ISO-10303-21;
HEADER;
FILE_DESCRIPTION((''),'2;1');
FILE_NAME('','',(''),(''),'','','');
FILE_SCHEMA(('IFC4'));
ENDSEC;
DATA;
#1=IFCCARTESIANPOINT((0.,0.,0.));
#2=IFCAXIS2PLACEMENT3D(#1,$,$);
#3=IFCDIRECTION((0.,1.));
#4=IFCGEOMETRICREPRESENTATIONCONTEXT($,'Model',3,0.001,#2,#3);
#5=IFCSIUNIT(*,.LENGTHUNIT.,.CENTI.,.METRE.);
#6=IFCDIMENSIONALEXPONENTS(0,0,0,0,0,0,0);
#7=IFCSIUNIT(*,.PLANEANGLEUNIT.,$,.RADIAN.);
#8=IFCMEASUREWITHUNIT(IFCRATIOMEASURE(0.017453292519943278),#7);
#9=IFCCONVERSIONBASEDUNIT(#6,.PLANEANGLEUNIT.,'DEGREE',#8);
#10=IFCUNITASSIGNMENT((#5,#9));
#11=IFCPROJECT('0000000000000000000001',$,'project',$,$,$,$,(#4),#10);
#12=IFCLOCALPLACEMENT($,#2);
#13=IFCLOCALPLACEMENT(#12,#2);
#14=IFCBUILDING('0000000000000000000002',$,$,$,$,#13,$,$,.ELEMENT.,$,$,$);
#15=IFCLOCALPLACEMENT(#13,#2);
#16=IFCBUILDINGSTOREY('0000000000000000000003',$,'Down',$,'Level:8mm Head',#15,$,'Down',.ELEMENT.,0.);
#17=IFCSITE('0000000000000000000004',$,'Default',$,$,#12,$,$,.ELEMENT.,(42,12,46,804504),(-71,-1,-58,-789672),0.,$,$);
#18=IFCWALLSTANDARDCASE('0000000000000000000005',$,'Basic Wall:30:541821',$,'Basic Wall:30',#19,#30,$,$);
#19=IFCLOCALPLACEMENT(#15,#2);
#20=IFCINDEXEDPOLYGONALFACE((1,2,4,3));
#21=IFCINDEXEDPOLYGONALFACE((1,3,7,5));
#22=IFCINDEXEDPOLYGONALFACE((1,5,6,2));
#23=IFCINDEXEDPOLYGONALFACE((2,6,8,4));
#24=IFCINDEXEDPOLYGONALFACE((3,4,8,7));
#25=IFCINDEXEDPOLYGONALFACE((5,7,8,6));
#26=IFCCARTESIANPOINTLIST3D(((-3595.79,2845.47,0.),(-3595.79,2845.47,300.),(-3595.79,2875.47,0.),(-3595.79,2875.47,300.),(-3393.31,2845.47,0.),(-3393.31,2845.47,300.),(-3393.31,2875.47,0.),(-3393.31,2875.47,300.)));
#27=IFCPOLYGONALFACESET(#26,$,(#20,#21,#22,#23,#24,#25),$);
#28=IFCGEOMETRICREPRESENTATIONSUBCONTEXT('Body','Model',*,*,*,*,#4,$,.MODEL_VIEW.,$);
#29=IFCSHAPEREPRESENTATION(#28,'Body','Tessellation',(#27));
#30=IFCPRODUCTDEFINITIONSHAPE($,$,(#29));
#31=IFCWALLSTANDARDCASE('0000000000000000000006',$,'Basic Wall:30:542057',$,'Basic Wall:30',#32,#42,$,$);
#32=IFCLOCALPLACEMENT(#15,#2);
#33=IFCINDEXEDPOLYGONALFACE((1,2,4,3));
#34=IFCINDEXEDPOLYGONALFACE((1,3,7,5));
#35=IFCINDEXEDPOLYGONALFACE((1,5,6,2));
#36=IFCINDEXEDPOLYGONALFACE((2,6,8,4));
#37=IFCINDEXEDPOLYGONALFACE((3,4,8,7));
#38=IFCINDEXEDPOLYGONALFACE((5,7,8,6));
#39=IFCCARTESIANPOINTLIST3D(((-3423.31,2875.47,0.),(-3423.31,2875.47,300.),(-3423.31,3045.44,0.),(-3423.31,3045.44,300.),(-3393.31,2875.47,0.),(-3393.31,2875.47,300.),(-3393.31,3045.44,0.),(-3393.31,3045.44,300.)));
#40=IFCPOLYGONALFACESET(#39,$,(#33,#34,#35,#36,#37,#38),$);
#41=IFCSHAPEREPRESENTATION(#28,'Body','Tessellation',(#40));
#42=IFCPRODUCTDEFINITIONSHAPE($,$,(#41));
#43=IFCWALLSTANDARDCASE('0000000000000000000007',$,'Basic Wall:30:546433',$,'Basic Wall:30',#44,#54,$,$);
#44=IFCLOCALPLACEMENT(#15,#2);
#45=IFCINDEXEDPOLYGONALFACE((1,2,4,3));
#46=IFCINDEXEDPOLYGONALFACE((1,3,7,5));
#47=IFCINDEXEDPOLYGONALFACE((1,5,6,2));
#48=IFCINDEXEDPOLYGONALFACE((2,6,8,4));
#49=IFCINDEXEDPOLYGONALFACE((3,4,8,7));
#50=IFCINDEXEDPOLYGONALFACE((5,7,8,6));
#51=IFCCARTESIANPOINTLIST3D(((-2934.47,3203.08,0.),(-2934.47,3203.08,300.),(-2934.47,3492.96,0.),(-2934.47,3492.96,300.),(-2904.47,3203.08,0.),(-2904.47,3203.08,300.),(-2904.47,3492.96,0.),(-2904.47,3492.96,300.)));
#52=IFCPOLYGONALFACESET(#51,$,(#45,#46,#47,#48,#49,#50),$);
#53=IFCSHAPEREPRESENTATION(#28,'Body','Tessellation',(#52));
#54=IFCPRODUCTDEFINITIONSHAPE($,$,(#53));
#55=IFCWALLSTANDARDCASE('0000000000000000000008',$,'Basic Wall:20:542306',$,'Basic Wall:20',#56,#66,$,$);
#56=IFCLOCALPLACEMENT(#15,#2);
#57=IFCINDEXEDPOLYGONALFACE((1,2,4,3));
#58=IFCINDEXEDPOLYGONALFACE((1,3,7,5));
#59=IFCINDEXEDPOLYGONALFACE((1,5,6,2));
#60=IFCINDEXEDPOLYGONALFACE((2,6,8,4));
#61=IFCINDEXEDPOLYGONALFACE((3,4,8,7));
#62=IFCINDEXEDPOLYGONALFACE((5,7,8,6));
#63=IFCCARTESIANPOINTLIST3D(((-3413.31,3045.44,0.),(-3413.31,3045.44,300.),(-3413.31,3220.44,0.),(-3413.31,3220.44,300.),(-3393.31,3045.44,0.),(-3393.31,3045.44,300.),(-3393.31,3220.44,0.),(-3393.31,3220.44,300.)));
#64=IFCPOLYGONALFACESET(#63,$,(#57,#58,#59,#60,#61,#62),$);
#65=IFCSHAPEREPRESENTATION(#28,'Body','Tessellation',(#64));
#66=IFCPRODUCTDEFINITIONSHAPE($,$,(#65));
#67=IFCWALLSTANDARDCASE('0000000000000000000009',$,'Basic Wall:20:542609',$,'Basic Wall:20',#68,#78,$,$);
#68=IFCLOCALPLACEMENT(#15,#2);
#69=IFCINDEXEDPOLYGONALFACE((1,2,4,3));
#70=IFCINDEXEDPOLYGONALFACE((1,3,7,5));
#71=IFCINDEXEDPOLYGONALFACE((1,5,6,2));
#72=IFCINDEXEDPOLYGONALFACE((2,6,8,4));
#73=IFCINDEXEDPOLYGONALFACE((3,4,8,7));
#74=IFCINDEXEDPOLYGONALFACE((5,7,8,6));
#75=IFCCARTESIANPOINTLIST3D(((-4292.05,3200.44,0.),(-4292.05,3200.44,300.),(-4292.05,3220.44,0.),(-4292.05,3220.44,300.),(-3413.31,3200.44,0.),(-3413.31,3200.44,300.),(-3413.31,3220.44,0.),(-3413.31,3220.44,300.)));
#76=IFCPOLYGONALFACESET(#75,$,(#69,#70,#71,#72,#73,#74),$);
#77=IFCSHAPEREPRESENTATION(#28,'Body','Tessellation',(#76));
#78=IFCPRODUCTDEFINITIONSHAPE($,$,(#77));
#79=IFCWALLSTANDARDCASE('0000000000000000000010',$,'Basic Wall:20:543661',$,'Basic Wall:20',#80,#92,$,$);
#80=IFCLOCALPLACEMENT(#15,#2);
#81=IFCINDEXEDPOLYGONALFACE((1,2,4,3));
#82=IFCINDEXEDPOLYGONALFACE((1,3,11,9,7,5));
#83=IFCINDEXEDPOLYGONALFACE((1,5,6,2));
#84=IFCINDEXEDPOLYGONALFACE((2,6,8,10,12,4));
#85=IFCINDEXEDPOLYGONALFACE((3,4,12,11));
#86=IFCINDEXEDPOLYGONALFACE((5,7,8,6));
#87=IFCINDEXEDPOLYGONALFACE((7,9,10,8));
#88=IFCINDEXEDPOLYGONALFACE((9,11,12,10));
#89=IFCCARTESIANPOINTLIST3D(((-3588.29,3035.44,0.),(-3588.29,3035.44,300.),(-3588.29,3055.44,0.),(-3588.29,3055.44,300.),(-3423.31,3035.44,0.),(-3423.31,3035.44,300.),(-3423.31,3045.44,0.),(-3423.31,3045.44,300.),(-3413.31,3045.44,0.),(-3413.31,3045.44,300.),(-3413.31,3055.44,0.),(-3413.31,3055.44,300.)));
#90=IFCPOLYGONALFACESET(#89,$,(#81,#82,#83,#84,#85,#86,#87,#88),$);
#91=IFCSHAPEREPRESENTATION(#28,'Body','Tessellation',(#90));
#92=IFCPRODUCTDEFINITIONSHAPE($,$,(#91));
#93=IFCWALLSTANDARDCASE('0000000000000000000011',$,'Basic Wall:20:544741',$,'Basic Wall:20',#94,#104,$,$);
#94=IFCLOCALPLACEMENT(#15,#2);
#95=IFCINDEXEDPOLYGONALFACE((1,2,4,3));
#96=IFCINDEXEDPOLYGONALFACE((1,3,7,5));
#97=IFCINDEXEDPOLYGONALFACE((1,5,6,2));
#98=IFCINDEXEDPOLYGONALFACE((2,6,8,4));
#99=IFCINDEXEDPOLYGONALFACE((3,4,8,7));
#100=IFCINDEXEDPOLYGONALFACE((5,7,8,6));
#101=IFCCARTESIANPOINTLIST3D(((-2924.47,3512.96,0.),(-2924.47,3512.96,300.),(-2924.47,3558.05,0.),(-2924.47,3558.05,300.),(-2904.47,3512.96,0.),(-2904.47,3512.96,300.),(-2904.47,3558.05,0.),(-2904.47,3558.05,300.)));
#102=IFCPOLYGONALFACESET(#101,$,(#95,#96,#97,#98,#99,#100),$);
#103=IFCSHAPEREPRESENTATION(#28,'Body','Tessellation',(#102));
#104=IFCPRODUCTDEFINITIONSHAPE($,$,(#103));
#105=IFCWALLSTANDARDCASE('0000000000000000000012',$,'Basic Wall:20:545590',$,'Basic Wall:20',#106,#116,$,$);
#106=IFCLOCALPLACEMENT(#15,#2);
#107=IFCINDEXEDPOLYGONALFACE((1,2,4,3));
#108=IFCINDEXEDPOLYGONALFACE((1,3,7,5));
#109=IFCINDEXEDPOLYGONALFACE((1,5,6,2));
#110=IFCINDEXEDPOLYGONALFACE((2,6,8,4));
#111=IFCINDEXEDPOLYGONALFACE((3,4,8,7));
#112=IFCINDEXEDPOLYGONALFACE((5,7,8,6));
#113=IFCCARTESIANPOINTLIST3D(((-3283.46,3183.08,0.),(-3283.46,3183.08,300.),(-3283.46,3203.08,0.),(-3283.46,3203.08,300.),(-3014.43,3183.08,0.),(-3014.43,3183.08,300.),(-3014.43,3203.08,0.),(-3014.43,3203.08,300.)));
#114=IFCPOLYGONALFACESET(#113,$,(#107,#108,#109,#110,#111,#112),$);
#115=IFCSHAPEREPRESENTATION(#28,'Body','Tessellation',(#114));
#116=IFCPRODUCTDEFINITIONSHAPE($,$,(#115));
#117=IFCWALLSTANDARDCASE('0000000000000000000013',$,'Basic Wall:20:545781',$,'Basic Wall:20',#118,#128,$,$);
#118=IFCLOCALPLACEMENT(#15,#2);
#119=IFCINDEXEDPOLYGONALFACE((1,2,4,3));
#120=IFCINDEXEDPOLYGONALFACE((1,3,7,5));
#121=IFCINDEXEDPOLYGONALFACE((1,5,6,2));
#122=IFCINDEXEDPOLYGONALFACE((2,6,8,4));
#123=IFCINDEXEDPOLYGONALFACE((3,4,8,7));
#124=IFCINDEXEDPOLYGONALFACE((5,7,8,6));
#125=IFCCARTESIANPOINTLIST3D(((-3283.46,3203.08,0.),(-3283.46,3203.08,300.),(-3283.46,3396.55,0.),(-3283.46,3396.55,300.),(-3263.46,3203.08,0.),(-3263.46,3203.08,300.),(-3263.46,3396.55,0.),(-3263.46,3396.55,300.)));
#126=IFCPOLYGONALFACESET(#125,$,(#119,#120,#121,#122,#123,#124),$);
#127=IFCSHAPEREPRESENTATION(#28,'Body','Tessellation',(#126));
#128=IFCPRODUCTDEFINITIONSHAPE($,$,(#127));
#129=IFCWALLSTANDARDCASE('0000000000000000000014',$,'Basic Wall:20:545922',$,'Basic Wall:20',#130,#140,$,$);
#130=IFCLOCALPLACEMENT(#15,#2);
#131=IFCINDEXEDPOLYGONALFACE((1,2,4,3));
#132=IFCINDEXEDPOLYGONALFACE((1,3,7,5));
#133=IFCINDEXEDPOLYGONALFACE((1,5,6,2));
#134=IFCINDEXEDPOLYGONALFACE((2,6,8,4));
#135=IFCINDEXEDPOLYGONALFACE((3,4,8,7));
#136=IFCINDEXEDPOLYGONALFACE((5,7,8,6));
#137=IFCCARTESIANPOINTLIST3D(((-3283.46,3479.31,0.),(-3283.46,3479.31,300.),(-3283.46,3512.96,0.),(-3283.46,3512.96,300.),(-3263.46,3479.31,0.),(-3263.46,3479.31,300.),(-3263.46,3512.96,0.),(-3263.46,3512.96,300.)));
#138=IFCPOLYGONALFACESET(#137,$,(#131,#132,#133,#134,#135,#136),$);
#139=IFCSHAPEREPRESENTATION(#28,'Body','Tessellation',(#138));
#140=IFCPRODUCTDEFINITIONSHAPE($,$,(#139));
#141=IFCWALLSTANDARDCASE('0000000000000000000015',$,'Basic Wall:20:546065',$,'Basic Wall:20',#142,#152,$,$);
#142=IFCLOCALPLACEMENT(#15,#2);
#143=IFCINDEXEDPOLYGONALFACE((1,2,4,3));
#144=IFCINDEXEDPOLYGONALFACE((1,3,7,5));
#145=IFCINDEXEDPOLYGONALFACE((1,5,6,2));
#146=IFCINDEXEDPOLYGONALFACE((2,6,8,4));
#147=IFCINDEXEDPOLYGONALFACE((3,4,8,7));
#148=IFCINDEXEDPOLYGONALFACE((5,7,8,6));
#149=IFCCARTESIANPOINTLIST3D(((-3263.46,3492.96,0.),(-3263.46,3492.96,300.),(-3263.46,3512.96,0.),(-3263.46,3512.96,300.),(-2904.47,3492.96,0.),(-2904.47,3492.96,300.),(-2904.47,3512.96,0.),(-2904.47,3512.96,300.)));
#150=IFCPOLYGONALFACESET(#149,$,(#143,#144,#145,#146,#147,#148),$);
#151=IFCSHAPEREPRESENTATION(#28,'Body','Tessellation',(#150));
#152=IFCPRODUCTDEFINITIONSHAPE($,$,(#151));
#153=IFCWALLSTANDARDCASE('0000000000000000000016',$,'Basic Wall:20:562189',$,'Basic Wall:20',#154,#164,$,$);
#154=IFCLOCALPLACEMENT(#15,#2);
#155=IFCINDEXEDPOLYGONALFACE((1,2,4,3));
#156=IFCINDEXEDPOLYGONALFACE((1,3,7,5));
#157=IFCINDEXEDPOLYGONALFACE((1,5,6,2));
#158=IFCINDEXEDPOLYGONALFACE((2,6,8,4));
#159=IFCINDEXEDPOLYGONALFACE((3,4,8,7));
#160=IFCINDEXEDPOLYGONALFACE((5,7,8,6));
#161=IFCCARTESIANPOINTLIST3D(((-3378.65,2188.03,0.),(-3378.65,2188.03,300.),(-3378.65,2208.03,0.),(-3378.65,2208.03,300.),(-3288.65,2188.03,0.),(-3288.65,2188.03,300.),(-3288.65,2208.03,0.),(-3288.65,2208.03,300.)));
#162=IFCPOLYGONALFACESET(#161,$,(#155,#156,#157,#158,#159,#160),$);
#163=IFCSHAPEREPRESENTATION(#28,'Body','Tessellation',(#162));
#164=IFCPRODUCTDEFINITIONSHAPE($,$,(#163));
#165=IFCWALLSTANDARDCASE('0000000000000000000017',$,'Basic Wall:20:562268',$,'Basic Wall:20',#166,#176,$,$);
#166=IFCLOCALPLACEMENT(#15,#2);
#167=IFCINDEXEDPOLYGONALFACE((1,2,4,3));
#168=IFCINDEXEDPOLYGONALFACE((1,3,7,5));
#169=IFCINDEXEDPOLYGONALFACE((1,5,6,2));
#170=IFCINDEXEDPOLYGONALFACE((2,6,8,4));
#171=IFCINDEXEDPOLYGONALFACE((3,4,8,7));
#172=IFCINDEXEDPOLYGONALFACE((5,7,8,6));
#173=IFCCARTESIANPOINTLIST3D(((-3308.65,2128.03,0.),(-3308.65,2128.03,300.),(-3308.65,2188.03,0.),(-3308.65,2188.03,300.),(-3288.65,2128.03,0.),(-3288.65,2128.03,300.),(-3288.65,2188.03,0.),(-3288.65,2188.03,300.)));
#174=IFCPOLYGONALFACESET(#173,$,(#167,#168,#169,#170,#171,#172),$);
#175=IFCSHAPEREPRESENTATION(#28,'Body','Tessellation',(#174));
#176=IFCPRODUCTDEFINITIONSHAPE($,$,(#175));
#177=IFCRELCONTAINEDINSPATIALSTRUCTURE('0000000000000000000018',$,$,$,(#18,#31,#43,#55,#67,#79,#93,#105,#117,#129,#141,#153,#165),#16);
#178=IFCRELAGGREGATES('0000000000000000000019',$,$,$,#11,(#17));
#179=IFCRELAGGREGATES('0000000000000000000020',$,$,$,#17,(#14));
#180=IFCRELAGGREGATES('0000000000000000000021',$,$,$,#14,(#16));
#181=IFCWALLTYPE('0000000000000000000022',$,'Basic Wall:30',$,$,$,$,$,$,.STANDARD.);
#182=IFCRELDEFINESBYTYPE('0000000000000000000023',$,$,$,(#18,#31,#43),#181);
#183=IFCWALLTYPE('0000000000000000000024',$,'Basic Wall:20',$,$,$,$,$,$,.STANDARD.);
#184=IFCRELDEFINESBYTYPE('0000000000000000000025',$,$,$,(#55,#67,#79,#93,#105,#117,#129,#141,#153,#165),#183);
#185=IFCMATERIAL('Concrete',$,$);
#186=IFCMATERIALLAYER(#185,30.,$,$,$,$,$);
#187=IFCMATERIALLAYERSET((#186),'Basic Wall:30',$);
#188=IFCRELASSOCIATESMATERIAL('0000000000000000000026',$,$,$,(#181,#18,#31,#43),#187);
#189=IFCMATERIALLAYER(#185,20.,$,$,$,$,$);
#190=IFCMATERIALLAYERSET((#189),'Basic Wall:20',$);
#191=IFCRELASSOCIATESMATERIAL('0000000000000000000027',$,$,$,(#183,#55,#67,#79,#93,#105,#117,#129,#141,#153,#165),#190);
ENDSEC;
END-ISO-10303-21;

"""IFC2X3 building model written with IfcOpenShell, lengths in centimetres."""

from ifc_helpers import new_model, entity, si_unit, converted_unit, direction, frame, frame_2d, origin, place, context, subcontext, project, spatial, polyline, rectangle, outline, extrude, material, layer, layer_set, layer_usage, type_object, element, save


model = new_model("IFC2X3")

# Units and contexts
model_context = context("Model", 3, precision=0.001, world=origin(), true_north=direction((0.0, 1.0)))
body_context = subcontext(model_context, "Body", "Model", "MODEL_VIEW")
ifc_project = project(units=[si_unit("LENGTHUNIT", "METRE", prefix="CENTI"), converted_unit("PLANEANGLEUNIT", "DEGREE", entity("IfcRatioMeasure", 0.017453292519943278), si_unit("PLANEANGLEUNIT", "RADIAN"), dimensions=[0, 0, 0, 0, 0, 0, 0])], contexts=[model_context])

# Site, building, storey
site_placement = place(None, origin())
site = spatial("IfcSite", under=ifc_project, at=site_placement, Name="Default", CompositionType="ELEMENT", RefLatitude=(42, 12, 46, 804504), RefLongitude=(-71, -1, -58, -789672), RefElevation=0.0)
building_placement = place(site_placement, origin())
building = spatial("IfcBuilding", under=site, at=building_placement, CompositionType="ELEMENT")
storey_placement = place(building_placement, origin())
storey = spatial("IfcBuildingStorey", under=building, at=storey_placement, Name="Down", ObjectType="Level:8mm Head", LongName="Down", CompositionType="ELEMENT", Elevation=0.0)

# Shared definitions
ifc_material = material(Name="Concrete")

# Walls
ifc_layer_1 = layer(ifc_material, 30.0)
ifc_layer_set_1 = layer_set([ifc_layer_1], Name="Basic Wall:30")
ifc_layer_usage_1 = layer_usage(ifc_layer_set_1, "AXIS2", "NEGATIVE", 15.0)
wall_type_1 = type_object("IfcWallType", Name="Basic Wall:30", PredefinedType="STANDARD", material=ifc_layer_set_1)
wall_1_placement = place(storey_placement, frame((-3393.31, 2860.47, 0.0), z_axis=(0.0, 0.0, 1.0), x_axis=(-1.0, 0.0, 0.0)))
element("IfcWallStandardCase", 1, at=wall_1_placement, inside=storey, type_object=wall_type_1, material=ifc_layer_usage_1, Name="Basic Wall:30:541821", ObjectType="Basic Wall:30", context=body_context, shape_type="SweptSolid", body=[
    extrude(rectangle(XDim=202.48, YDim=30.0, at=frame_2d((101.24, 0.0), x_axis=(-1.0, 0.0))), origin(), (0.0, 0.0, 1.0), 300.0),
])
ifc_layer_usage_2 = layer_usage(ifc_layer_set_1, "AXIS2", "POSITIVE", -15.0)
wall_2_placement = place(storey_placement, frame((-3408.31, 2875.47, 0.0), z_axis=(0.0, 0.0, 1.0), x_axis=(0.0, 1.0, 0.0)))
element("IfcWallStandardCase", 2, at=wall_2_placement, inside=storey, type_object=wall_type_1, material=ifc_layer_usage_2, Name="Basic Wall:30:542057", ObjectType="Basic Wall:30", context=body_context, shape_type="SweptSolid", body=[
    extrude(rectangle(XDim=169.97, YDim=30.0, at=frame_2d((84.99, 0.0), x_axis=(-1.0, 0.0))), origin(), (0.0, 0.0, 1.0), 300.0),
])
ifc_layer_usage_3 = layer_usage(ifc_layer_set_1, "AXIS2", "NEGATIVE", 15.0)
wall_3_placement = place(storey_placement, frame((-2919.47, 3492.96, 0.0), z_axis=(0.0, 0.0, 1.0), x_axis=(0.0, -1.0, 0.0)))
element("IfcWallStandardCase", 3, at=wall_3_placement, inside=storey, type_object=wall_type_1, material=ifc_layer_usage_3, Name="Basic Wall:30:546433", ObjectType="Basic Wall:30", context=body_context, shape_type="SweptSolid", body=[
    extrude(rectangle(XDim=289.88, YDim=30.0, at=frame_2d((144.94, 0.0), x_axis=(-1.0, 0.0))), origin(), (0.0, 0.0, 1.0), 300.0),
])
ifc_layer_2 = layer(ifc_material, 20.0)
ifc_layer_set_2 = layer_set([ifc_layer_2], Name="Basic Wall:20")
ifc_layer_usage_4 = layer_usage(ifc_layer_set_2, "AXIS2", "POSITIVE", -10.0)
wall_type_2 = type_object("IfcWallType", Name="Basic Wall:20", PredefinedType="STANDARD", material=ifc_layer_set_2)
wall_4_placement = place(storey_placement, frame((-3403.31, 3045.44, 0.0), z_axis=(0.0, 0.0, 1.0), x_axis=(0.0, 1.0, 0.0)))
element("IfcWallStandardCase", 4, at=wall_4_placement, inside=storey, type_object=wall_type_2, material=ifc_layer_usage_4, Name="Basic Wall:20:542306", ObjectType="Basic Wall:20", context=body_context, shape_type="SweptSolid", body=[
    extrude(rectangle(XDim=175.0, YDim=20.0, at=frame_2d((87.5, 0.0), x_axis=(-1.0, 0.0))), origin(), (0.0, 0.0, 1.0), 300.0),
])
ifc_layer_usage_5 = layer_usage(ifc_layer_set_2, "AXIS2", "POSITIVE", -10.0)
wall_5_placement = place(storey_placement, frame((-3413.31, 3210.44, 0.0), z_axis=(0.0, 0.0, 1.0), x_axis=(-1.0, 0.0, 0.0)))
element("IfcWallStandardCase", 5, at=wall_5_placement, inside=storey, type_object=wall_type_2, material=ifc_layer_usage_5, Name="Basic Wall:20:542609", ObjectType="Basic Wall:20", context=body_context, shape_type="SweptSolid", body=[
    extrude(rectangle(XDim=878.74, YDim=20.0, at=frame_2d((439.37, 0.0), x_axis=(-1.0, 0.0))), origin(), (0.0, 0.0, 1.0), 300.0),
])
ifc_layer_usage_6 = layer_usage(ifc_layer_set_2, "AXIS2", "NEGATIVE", 10.0)
wall_6_placement = place(storey_placement, frame((-3413.31, 3045.44, 0.0), z_axis=(0.0, 0.0, 1.0), x_axis=(-1.0, 0.0, 0.0)))
element("IfcWallStandardCase", 6, at=wall_6_placement, inside=storey, type_object=wall_type_2, material=ifc_layer_usage_6, Name="Basic Wall:20:543661", ObjectType="Basic Wall:20", context=body_context, shape_type="SweptSolid", body=[
    extrude(outline(polyline([(174.98, -10.0), (174.98, 10.0), (10.0, 10.0), (10.0, 0.0), (0.0, 0.0), (0.0, -10.0), (174.98, -10.0)])), origin(), (0.0, 0.0, 1.0), 300.0),
])
ifc_layer_usage_7 = layer_usage(ifc_layer_set_2, "AXIS2", "POSITIVE", -10.0)
wall_7_placement = place(storey_placement, frame((-2914.47, 3558.05, 0.0), z_axis=(0.0, 0.0, 1.0), x_axis=(0.0, -1.0, 0.0)))
element("IfcWallStandardCase", 7, at=wall_7_placement, inside=storey, type_object=wall_type_2, material=ifc_layer_usage_7, Name="Basic Wall:20:544741", ObjectType="Basic Wall:20", context=body_context, shape_type="SweptSolid", body=[
    extrude(rectangle(XDim=45.08, YDim=20.0, at=frame_2d((22.54, 0.0), x_axis=(-1.0, 0.0))), origin(), (0.0, 0.0, 1.0), 300.0),
])
ifc_layer_usage_8 = layer_usage(ifc_layer_set_2, "AXIS2", "POSITIVE", -10.0)
wall_8_placement = place(storey_placement, frame((-3014.43, 3193.08, 0.0), z_axis=(0.0, 0.0, 1.0), x_axis=(-1.0, 0.0, 0.0)))
element("IfcWallStandardCase", 8, at=wall_8_placement, inside=storey, type_object=wall_type_2, material=ifc_layer_usage_8, Name="Basic Wall:20:545590", ObjectType="Basic Wall:20", context=body_context, shape_type="SweptSolid", body=[
    extrude(rectangle(XDim=269.03, YDim=20.0, at=frame_2d((134.51, 0.0), x_axis=(-1.0, 0.0))), origin(), (0.0, 0.0, 1.0), 300.0),
])
ifc_layer_usage_9 = layer_usage(ifc_layer_set_2, "AXIS2", "NEGATIVE", 10.0)
wall_9_placement = place(storey_placement, frame((-3273.46, 3203.08, 0.0), z_axis=(0.0, 0.0, 1.0), x_axis=(0.0, 1.0, 0.0)))
element("IfcWallStandardCase", 9, at=wall_9_placement, inside=storey, type_object=wall_type_2, material=ifc_layer_usage_9, Name="Basic Wall:20:545781", ObjectType="Basic Wall:20", context=body_context, shape_type="SweptSolid", body=[
    extrude(rectangle(XDim=193.46, YDim=20.0, at=frame_2d((96.73, 0.0), x_axis=(-1.0, 0.0))), origin(), (0.0, 0.0, 1.0), 300.0),
])
ifc_layer_usage_10 = layer_usage(ifc_layer_set_2, "AXIS2", "NEGATIVE", 10.0)
wall_10_placement = place(storey_placement, frame((-3273.46, 3479.31, 0.0), z_axis=(0.0, 0.0, 1.0), x_axis=(0.0, 1.0, 0.0)))
element("IfcWallStandardCase", 10, at=wall_10_placement, inside=storey, type_object=wall_type_2, material=ifc_layer_usage_10, Name="Basic Wall:20:545922", ObjectType="Basic Wall:20", context=body_context, shape_type="SweptSolid", body=[
    extrude(rectangle(XDim=33.66, YDim=20.0, at=frame_2d((16.83, 0.0), x_axis=(-1.0, 0.0))), origin(), (0.0, 0.0, 1.0), 300.0),
])
ifc_layer_usage_11 = layer_usage(ifc_layer_set_2, "AXIS2", "NEGATIVE", 10.0)
wall_11_placement = place(storey_placement, frame((-3263.46, 3502.96, 0.0)))
element("IfcWallStandardCase", 11, at=wall_11_placement, inside=storey, type_object=wall_type_2, material=ifc_layer_usage_11, Name="Basic Wall:20:546065", ObjectType="Basic Wall:20", context=body_context, shape_type="SweptSolid", body=[
    extrude(rectangle(XDim=358.99, YDim=20.0, at=frame_2d((179.49, 0.0), x_axis=(-1.0, 0.0))), origin(), (0.0, 0.0, 1.0), 300.0),
])
ifc_layer_usage_12 = layer_usage(ifc_layer_set_2, "AXIS2", "NEGATIVE", 10.0)
wall_12_placement = place(storey_placement, frame((-3378.65, 2198.03, 0.0)))
element("IfcWallStandardCase", 12, at=wall_12_placement, inside=storey, type_object=wall_type_2, material=ifc_layer_usage_12, Name="Basic Wall:20:562189", ObjectType="Basic Wall:20", context=body_context, shape_type="SweptSolid", body=[
    extrude(rectangle(XDim=90.0, YDim=20.0, at=frame_2d((45.0, 0.0), x_axis=(-1.0, 0.0))), origin(), (0.0, 0.0, 1.0), 300.0),
])
ifc_layer_usage_13 = layer_usage(ifc_layer_set_2, "AXIS2", "NEGATIVE", 10.0)
wall_13_placement = place(storey_placement, frame((-3298.65, 2188.03, 0.0), z_axis=(0.0, 0.0, 1.0), x_axis=(0.0, -1.0, 0.0)))
element("IfcWallStandardCase", 13, at=wall_13_placement, inside=storey, type_object=wall_type_2, material=ifc_layer_usage_13, Name="Basic Wall:20:562268", ObjectType="Basic Wall:20", context=body_context, shape_type="SweptSolid", body=[
    extrude(rectangle(XDim=60.0, YDim=20.0, at=frame_2d((30.0, 0.0), x_axis=(-1.0, 0.0))), origin(), (0.0, 0.0, 1.0), 300.0),
])

save(model, "model.ifc")
